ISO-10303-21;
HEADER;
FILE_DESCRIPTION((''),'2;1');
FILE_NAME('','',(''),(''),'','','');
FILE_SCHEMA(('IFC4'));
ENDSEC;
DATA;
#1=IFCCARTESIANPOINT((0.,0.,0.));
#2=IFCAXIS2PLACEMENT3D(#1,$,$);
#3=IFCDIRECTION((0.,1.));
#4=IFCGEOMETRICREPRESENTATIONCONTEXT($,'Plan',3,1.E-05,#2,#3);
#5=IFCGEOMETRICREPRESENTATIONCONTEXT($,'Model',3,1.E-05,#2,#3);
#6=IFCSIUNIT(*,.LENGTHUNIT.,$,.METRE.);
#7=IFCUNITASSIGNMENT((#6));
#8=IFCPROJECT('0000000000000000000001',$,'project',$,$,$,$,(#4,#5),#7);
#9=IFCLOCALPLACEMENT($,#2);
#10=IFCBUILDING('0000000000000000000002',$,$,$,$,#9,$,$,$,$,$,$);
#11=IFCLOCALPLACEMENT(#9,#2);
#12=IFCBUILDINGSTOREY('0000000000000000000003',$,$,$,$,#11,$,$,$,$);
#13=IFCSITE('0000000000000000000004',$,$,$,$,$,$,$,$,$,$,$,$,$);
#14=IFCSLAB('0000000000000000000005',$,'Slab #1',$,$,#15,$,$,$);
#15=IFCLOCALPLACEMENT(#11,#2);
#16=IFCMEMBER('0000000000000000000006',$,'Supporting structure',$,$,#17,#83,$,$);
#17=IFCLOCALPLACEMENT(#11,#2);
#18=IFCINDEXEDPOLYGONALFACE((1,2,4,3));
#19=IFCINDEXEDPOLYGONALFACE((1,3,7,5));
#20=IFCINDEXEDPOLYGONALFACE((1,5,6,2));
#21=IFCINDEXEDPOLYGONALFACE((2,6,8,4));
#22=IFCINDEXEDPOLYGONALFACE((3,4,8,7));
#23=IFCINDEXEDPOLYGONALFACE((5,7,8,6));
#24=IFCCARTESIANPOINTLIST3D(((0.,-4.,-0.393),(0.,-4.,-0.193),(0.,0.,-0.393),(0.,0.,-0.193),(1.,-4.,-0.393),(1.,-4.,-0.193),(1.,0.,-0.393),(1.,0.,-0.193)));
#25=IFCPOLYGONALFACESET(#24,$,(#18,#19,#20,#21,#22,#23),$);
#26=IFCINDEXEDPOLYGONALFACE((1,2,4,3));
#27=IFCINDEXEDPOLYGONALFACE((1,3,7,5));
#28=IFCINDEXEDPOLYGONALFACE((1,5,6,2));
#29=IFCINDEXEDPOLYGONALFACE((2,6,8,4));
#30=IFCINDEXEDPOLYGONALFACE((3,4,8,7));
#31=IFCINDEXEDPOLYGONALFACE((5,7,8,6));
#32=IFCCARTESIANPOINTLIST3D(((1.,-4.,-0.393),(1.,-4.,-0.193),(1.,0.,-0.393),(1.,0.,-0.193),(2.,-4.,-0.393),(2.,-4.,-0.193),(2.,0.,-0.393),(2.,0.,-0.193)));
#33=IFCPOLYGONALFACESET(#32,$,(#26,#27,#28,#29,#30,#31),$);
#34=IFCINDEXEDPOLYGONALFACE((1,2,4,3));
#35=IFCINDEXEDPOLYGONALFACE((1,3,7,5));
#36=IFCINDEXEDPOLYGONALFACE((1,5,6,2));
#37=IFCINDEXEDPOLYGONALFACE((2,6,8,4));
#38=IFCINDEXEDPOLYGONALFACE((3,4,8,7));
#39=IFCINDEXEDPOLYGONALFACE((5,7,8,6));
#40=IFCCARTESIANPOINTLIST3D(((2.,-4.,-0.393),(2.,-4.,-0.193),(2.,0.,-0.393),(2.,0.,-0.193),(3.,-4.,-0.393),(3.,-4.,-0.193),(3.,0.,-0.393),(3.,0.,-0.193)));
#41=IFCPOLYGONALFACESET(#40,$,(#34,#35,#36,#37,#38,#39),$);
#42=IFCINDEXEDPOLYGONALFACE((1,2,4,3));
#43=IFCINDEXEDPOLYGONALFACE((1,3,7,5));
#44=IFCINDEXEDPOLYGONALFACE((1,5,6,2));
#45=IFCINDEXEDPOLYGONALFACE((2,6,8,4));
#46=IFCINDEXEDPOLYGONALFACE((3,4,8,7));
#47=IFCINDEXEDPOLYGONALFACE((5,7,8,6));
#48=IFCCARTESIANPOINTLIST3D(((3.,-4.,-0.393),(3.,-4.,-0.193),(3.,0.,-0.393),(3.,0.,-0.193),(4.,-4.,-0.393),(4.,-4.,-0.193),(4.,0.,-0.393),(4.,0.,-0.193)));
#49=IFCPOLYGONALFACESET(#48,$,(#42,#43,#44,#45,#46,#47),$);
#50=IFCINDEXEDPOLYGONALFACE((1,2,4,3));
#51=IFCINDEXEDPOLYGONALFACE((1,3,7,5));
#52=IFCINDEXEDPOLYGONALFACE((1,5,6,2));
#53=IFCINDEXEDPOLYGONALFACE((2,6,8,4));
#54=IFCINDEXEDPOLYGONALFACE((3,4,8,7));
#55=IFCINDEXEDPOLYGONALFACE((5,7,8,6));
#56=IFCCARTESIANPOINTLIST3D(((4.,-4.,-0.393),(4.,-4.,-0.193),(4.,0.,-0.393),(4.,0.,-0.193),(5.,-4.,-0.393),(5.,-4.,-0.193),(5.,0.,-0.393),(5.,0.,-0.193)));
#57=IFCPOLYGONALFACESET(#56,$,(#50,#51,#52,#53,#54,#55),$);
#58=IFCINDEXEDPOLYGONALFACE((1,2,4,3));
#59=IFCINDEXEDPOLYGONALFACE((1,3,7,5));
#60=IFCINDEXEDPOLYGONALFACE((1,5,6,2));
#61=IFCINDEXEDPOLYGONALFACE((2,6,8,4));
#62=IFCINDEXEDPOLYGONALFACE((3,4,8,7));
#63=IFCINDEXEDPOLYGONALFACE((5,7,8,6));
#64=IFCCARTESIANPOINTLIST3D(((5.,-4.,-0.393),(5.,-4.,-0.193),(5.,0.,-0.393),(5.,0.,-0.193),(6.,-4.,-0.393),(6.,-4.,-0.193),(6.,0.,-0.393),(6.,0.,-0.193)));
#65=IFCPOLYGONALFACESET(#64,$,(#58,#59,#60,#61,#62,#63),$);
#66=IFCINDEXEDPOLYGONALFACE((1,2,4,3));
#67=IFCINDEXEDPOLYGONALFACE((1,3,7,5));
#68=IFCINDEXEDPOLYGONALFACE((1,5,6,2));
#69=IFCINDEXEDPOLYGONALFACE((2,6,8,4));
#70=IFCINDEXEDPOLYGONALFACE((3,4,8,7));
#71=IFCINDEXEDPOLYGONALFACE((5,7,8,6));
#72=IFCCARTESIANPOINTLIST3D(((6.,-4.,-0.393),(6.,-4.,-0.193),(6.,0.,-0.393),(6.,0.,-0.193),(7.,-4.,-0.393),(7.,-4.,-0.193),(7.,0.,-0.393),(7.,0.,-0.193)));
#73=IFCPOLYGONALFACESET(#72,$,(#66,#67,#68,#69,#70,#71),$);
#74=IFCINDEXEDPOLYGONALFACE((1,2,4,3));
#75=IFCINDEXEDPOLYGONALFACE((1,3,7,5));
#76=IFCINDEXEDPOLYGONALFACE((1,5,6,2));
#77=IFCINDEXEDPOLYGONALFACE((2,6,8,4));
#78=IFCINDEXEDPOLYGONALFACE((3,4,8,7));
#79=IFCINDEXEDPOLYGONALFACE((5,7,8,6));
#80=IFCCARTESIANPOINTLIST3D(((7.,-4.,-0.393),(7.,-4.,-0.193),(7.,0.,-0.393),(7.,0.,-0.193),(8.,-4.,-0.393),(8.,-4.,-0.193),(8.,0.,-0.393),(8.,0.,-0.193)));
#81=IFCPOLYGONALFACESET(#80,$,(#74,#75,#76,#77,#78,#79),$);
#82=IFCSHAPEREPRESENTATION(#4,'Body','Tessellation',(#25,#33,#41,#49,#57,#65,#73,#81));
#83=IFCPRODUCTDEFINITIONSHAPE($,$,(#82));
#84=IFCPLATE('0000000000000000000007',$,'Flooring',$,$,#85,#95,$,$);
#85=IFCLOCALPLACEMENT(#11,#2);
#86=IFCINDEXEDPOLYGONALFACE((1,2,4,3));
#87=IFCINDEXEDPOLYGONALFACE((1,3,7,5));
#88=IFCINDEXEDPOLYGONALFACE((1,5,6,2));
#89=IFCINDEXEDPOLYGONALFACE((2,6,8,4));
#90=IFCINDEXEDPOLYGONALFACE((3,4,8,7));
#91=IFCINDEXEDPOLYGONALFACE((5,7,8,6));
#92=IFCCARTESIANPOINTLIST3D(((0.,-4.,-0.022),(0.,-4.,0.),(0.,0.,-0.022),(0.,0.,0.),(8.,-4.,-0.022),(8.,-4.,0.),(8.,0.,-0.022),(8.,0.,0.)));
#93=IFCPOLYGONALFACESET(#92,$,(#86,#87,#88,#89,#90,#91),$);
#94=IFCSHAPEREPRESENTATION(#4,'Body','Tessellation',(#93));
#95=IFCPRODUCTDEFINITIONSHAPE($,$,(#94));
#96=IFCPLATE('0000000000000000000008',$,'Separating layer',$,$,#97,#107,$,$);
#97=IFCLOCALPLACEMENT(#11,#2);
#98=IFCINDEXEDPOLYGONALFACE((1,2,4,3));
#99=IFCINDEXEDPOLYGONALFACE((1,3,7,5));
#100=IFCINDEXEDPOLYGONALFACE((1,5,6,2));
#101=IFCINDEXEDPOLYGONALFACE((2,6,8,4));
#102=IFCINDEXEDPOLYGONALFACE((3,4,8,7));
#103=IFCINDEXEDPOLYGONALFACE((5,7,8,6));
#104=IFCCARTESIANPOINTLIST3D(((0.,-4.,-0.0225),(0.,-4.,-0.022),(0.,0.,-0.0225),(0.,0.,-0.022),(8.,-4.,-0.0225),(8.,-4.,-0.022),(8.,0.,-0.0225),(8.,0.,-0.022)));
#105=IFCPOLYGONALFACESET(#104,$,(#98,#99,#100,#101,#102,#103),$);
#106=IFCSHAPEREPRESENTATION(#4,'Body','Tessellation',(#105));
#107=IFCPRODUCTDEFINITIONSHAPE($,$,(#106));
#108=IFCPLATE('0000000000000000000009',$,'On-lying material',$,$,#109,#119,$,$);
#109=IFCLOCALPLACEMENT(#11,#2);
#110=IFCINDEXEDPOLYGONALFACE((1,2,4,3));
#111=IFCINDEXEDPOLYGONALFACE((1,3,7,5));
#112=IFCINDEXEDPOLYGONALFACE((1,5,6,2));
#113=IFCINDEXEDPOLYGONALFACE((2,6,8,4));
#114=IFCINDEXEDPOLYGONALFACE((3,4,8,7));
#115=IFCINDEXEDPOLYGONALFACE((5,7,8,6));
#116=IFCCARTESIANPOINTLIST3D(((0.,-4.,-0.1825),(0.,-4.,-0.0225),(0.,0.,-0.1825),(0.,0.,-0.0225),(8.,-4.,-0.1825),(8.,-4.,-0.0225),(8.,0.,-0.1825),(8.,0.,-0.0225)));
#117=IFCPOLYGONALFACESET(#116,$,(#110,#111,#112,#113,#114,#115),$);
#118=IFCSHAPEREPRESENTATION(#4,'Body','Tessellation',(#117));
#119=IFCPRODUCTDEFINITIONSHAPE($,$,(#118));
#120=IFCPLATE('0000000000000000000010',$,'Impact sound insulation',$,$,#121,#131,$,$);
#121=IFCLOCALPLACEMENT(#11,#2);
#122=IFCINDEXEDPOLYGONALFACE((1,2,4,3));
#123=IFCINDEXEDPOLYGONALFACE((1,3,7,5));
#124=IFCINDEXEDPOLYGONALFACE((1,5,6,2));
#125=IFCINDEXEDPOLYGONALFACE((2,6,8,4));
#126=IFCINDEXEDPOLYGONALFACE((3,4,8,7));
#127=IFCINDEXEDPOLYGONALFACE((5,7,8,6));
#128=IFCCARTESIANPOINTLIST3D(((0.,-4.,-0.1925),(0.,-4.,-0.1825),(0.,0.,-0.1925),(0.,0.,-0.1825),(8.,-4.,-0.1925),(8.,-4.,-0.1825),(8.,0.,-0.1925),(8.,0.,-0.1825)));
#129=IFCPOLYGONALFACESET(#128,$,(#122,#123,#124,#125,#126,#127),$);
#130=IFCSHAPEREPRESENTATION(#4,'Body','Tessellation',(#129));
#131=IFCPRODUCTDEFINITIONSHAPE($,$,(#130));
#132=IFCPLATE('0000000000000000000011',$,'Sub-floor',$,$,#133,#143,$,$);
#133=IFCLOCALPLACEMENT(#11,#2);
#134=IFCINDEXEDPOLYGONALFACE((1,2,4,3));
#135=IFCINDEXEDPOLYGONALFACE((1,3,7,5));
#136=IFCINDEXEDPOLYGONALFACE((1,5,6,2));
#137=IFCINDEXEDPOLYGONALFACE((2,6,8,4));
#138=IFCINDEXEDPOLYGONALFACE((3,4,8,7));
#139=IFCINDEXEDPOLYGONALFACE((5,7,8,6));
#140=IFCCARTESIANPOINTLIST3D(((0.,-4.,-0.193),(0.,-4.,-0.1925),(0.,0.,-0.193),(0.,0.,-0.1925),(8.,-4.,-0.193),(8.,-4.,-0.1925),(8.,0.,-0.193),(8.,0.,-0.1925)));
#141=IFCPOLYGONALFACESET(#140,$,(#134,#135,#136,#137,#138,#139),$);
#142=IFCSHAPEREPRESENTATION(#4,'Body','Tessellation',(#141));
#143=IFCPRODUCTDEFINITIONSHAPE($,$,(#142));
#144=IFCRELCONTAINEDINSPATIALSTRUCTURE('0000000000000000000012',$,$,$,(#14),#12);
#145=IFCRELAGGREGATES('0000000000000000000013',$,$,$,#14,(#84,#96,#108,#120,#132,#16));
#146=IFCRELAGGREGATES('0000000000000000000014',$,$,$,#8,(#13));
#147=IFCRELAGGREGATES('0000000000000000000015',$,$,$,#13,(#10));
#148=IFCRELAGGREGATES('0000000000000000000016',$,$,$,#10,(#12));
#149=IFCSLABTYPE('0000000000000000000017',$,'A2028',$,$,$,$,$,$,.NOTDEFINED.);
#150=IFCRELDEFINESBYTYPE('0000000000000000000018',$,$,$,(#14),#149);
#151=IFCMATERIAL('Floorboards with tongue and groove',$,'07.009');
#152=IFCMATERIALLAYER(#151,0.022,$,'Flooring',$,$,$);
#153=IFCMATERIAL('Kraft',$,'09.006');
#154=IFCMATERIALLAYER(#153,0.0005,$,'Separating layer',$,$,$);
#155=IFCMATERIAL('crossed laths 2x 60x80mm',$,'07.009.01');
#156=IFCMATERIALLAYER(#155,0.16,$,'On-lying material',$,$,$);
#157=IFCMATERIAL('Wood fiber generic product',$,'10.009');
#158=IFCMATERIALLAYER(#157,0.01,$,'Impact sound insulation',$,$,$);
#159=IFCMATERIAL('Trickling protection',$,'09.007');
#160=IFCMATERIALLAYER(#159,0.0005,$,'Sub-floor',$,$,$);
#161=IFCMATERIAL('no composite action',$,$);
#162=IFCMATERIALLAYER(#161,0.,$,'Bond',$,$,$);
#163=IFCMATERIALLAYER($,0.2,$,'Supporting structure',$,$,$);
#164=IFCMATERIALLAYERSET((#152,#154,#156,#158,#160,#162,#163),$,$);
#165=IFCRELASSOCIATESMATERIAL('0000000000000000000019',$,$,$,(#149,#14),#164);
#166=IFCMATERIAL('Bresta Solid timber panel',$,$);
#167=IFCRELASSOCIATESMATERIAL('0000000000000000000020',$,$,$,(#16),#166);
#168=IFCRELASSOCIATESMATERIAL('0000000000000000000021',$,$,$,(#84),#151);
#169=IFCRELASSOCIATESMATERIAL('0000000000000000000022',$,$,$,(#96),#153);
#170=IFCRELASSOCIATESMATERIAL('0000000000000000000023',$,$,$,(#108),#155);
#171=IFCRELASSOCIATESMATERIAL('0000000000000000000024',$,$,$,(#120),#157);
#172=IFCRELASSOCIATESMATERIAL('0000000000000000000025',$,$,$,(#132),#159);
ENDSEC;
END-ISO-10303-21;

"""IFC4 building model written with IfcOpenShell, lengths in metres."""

from ifc_helpers import new_model, si_unit, direction, frame, frame_2d, origin, origin_with_axes, place, context, project, spatial, rectangle, extrude, material, layer, layer_set, type_object, element, aggregate, save


model = new_model("IFC4")

# Units and contexts
plan_context = context("Plan", 3, precision=1e-05, world=origin(), true_north=direction((0.0, 1.0)))
model_context = context("Model", 3, precision=1e-05, world=origin(), true_north=direction((0.0, 1.0)))
ifc_project = project(units=[si_unit("LENGTHUNIT", "METRE")], contexts=[plan_context, model_context])

# Site, building, storey
site = spatial("IfcSite", under=ifc_project)
building_placement = place(None, origin())
building = spatial("IfcBuilding", under=site, at=building_placement)
storey_placement = place(building_placement, origin())
storey = spatial("IfcBuildingStorey", under=building, at=storey_placement)

# Slab, member, plates
ifc_material_1 = material(Name="Floorboards with tongue and groove", Category="07.009")
ifc_layer_1 = layer(ifc_material_1, 0.022, Name="Flooring")
ifc_material_2 = material(Name="Kraft", Category="09.006")
ifc_layer_2 = layer(ifc_material_2, 0.0005, Name="Separating layer")
ifc_material_3 = material(Name="crossed laths 2x 60x80mm", Category="07.009.01")
ifc_layer_3 = layer(ifc_material_3, 0.16, Name="On-lying material")
ifc_material_4 = material(Name="Wood fiber generic product", Category="10.009")
ifc_layer_4 = layer(ifc_material_4, 0.01, Name="Impact sound insulation")
ifc_material_5 = material(Name="Trickling protection", Category="09.007")
ifc_layer_5 = layer(ifc_material_5, 0.0005, Name="Sub-floor")
ifc_material_6 = material(Name="no composite action")
ifc_layer_6 = layer(ifc_material_6, 0.0, Name="Bond")
ifc_layer_7 = layer(None, 0.2, Name="Supporting structure")
ifc_layer_set = layer_set([ifc_layer_1, ifc_layer_2, ifc_layer_3, ifc_layer_4, ifc_layer_5, ifc_layer_6, ifc_layer_7])
slab_type = type_object("IfcSlabType", Name="A2028", PredefinedType="NOTDEFINED", material=ifc_layer_set)
slab_placement = place(None, frame((0.0, 0.0, 0.0), z_axis=(0.0, 0.0, -1.0), x_axis=(1.0, 0.0, 0.0)))
slab = element("IfcSlab", 1, at=slab_placement, inside=storey, type_object=slab_type, material=ifc_layer_set, Name="Slab #1")
ifc_material_7 = material(Name="Bresta Solid timber panel")
member_placement = place(slab_placement, origin())
member = element("IfcMember", 2, at=member_placement, material=ifc_material_7, Name="Supporting structure", context=plan_context, shape_type="SweptSolid", body=[
    extrude(rectangle(XDim=1.0, YDim=0.2, at=frame_2d((0.5, 0.1), x_axis=(1.0, 0.0))), frame((0.0, 4.0, 0.193), z_axis=(0.0, -1.0, 0.0), x_axis=(1.0, 0.0, 0.0)), (0.0, 0.0, 1.0), 4.0),
    extrude(rectangle(XDim=1.0, YDim=0.2, at=frame_2d((0.5, 0.1), x_axis=(1.0, 0.0))), frame((1.0, 4.0, 0.193), z_axis=(0.0, -1.0, 0.0), x_axis=(1.0, 0.0, 0.0)), (0.0, 0.0, 1.0), 4.0),
    extrude(rectangle(XDim=1.0, YDim=0.2, at=frame_2d((0.5, 0.1), x_axis=(1.0, 0.0))), frame((2.0, 4.0, 0.193), z_axis=(0.0, -1.0, 0.0), x_axis=(1.0, 0.0, 0.0)), (0.0, 0.0, 1.0), 4.0),
    extrude(rectangle(XDim=1.0, YDim=0.2, at=frame_2d((0.5, 0.1), x_axis=(1.0, 0.0))), frame((3.0, 4.0, 0.193), z_axis=(0.0, -1.0, 0.0), x_axis=(1.0, 0.0, 0.0)), (0.0, 0.0, 1.0), 4.0),
    extrude(rectangle(XDim=1.0, YDim=0.2, at=frame_2d((0.5, 0.1), x_axis=(1.0, 0.0))), frame((4.0, 4.0, 0.193), z_axis=(0.0, -1.0, 0.0), x_axis=(1.0, 0.0, 0.0)), (0.0, 0.0, 1.0), 4.0),
    extrude(rectangle(XDim=1.0, YDim=0.2, at=frame_2d((0.5, 0.1), x_axis=(1.0, 0.0))), frame((5.0, 4.0, 0.193), z_axis=(0.0, -1.0, 0.0), x_axis=(1.0, 0.0, 0.0)), (0.0, 0.0, 1.0), 4.0),
    extrude(rectangle(XDim=1.0, YDim=0.2, at=frame_2d((0.5, 0.1), x_axis=(1.0, 0.0))), frame((6.0, 4.0, 0.193), z_axis=(0.0, -1.0, 0.0), x_axis=(1.0, 0.0, 0.0)), (0.0, 0.0, 1.0), 4.0),
    extrude(rectangle(XDim=1.0, YDim=0.2, at=frame_2d((0.5, 0.1), x_axis=(1.0, 0.0))), frame((7.0, 4.0, 0.193), z_axis=(0.0, -1.0, 0.0), x_axis=(1.0, 0.0, 0.0)), (0.0, 0.0, 1.0), 4.0),
])
plate_1_placement = place(slab_placement, origin())
plate_1 = element("IfcPlate", 3, at=plate_1_placement, material=ifc_material_1, Name="Flooring", context=plan_context, shape_type="SweptSolid", body=[
    extrude(rectangle(XDim=8.0, YDim=4.0, at=frame_2d((4.0, 2.0), x_axis=(1.0, 0.0))), origin_with_axes(), (0.0, 0.0, 1.0), 0.022),
])
plate_2_placement = place(slab_placement, origin())
plate_2 = element("IfcPlate", 4, at=plate_2_placement, material=ifc_material_2, Name="Separating layer", context=plan_context, shape_type="SweptSolid", body=[
    extrude(rectangle(XDim=8.0, YDim=4.0, at=frame_2d((4.0, 2.0), x_axis=(1.0, 0.0))), frame((0.0, 0.0, 0.022), z_axis=(0.0, 0.0, 1.0), x_axis=(1.0, 0.0, 0.0)), (0.0, 0.0, 1.0), 0.0005),
])
plate_3_placement = place(slab_placement, origin())
plate_3 = element("IfcPlate", 5, at=plate_3_placement, material=ifc_material_3, Name="On-lying material", context=plan_context, shape_type="SweptSolid", body=[
    extrude(rectangle(XDim=8.0, YDim=4.0, at=frame_2d((4.0, 2.0), x_axis=(1.0, 0.0))), frame((0.0, 0.0, 0.0225), z_axis=(0.0, 0.0, 1.0), x_axis=(1.0, 0.0, 0.0)), (0.0, 0.0, 1.0), 0.16),
])
plate_4_placement = place(slab_placement, origin())
plate_4 = element("IfcPlate", 6, at=plate_4_placement, material=ifc_material_4, Name="Impact sound insulation", context=plan_context, shape_type="SweptSolid", body=[
    extrude(rectangle(XDim=8.0, YDim=4.0, at=frame_2d((4.0, 2.0), x_axis=(1.0, 0.0))), frame((0.0, 0.0, 0.1825), z_axis=(0.0, 0.0, 1.0), x_axis=(1.0, 0.0, 0.0)), (0.0, 0.0, 1.0), 0.01),
])
plate_5_placement = place(slab_placement, origin())
plate_5 = element("IfcPlate", 7, at=plate_5_placement, material=ifc_material_5, Name="Sub-floor", context=plan_context, shape_type="SweptSolid", body=[
    extrude(rectangle(XDim=8.0, YDim=4.0, at=frame_2d((4.0, 2.0), x_axis=(1.0, 0.0))), frame((0.0, 0.0, 0.1925), z_axis=(0.0, 0.0, 1.0), x_axis=(1.0, 0.0, 0.0)), (0.0, 0.0, 1.0), 0.0005),
])
aggregate(slab, [plate_1, plate_2, plate_3, plate_4, plate_5, member])

save(model, "model.ifc")
